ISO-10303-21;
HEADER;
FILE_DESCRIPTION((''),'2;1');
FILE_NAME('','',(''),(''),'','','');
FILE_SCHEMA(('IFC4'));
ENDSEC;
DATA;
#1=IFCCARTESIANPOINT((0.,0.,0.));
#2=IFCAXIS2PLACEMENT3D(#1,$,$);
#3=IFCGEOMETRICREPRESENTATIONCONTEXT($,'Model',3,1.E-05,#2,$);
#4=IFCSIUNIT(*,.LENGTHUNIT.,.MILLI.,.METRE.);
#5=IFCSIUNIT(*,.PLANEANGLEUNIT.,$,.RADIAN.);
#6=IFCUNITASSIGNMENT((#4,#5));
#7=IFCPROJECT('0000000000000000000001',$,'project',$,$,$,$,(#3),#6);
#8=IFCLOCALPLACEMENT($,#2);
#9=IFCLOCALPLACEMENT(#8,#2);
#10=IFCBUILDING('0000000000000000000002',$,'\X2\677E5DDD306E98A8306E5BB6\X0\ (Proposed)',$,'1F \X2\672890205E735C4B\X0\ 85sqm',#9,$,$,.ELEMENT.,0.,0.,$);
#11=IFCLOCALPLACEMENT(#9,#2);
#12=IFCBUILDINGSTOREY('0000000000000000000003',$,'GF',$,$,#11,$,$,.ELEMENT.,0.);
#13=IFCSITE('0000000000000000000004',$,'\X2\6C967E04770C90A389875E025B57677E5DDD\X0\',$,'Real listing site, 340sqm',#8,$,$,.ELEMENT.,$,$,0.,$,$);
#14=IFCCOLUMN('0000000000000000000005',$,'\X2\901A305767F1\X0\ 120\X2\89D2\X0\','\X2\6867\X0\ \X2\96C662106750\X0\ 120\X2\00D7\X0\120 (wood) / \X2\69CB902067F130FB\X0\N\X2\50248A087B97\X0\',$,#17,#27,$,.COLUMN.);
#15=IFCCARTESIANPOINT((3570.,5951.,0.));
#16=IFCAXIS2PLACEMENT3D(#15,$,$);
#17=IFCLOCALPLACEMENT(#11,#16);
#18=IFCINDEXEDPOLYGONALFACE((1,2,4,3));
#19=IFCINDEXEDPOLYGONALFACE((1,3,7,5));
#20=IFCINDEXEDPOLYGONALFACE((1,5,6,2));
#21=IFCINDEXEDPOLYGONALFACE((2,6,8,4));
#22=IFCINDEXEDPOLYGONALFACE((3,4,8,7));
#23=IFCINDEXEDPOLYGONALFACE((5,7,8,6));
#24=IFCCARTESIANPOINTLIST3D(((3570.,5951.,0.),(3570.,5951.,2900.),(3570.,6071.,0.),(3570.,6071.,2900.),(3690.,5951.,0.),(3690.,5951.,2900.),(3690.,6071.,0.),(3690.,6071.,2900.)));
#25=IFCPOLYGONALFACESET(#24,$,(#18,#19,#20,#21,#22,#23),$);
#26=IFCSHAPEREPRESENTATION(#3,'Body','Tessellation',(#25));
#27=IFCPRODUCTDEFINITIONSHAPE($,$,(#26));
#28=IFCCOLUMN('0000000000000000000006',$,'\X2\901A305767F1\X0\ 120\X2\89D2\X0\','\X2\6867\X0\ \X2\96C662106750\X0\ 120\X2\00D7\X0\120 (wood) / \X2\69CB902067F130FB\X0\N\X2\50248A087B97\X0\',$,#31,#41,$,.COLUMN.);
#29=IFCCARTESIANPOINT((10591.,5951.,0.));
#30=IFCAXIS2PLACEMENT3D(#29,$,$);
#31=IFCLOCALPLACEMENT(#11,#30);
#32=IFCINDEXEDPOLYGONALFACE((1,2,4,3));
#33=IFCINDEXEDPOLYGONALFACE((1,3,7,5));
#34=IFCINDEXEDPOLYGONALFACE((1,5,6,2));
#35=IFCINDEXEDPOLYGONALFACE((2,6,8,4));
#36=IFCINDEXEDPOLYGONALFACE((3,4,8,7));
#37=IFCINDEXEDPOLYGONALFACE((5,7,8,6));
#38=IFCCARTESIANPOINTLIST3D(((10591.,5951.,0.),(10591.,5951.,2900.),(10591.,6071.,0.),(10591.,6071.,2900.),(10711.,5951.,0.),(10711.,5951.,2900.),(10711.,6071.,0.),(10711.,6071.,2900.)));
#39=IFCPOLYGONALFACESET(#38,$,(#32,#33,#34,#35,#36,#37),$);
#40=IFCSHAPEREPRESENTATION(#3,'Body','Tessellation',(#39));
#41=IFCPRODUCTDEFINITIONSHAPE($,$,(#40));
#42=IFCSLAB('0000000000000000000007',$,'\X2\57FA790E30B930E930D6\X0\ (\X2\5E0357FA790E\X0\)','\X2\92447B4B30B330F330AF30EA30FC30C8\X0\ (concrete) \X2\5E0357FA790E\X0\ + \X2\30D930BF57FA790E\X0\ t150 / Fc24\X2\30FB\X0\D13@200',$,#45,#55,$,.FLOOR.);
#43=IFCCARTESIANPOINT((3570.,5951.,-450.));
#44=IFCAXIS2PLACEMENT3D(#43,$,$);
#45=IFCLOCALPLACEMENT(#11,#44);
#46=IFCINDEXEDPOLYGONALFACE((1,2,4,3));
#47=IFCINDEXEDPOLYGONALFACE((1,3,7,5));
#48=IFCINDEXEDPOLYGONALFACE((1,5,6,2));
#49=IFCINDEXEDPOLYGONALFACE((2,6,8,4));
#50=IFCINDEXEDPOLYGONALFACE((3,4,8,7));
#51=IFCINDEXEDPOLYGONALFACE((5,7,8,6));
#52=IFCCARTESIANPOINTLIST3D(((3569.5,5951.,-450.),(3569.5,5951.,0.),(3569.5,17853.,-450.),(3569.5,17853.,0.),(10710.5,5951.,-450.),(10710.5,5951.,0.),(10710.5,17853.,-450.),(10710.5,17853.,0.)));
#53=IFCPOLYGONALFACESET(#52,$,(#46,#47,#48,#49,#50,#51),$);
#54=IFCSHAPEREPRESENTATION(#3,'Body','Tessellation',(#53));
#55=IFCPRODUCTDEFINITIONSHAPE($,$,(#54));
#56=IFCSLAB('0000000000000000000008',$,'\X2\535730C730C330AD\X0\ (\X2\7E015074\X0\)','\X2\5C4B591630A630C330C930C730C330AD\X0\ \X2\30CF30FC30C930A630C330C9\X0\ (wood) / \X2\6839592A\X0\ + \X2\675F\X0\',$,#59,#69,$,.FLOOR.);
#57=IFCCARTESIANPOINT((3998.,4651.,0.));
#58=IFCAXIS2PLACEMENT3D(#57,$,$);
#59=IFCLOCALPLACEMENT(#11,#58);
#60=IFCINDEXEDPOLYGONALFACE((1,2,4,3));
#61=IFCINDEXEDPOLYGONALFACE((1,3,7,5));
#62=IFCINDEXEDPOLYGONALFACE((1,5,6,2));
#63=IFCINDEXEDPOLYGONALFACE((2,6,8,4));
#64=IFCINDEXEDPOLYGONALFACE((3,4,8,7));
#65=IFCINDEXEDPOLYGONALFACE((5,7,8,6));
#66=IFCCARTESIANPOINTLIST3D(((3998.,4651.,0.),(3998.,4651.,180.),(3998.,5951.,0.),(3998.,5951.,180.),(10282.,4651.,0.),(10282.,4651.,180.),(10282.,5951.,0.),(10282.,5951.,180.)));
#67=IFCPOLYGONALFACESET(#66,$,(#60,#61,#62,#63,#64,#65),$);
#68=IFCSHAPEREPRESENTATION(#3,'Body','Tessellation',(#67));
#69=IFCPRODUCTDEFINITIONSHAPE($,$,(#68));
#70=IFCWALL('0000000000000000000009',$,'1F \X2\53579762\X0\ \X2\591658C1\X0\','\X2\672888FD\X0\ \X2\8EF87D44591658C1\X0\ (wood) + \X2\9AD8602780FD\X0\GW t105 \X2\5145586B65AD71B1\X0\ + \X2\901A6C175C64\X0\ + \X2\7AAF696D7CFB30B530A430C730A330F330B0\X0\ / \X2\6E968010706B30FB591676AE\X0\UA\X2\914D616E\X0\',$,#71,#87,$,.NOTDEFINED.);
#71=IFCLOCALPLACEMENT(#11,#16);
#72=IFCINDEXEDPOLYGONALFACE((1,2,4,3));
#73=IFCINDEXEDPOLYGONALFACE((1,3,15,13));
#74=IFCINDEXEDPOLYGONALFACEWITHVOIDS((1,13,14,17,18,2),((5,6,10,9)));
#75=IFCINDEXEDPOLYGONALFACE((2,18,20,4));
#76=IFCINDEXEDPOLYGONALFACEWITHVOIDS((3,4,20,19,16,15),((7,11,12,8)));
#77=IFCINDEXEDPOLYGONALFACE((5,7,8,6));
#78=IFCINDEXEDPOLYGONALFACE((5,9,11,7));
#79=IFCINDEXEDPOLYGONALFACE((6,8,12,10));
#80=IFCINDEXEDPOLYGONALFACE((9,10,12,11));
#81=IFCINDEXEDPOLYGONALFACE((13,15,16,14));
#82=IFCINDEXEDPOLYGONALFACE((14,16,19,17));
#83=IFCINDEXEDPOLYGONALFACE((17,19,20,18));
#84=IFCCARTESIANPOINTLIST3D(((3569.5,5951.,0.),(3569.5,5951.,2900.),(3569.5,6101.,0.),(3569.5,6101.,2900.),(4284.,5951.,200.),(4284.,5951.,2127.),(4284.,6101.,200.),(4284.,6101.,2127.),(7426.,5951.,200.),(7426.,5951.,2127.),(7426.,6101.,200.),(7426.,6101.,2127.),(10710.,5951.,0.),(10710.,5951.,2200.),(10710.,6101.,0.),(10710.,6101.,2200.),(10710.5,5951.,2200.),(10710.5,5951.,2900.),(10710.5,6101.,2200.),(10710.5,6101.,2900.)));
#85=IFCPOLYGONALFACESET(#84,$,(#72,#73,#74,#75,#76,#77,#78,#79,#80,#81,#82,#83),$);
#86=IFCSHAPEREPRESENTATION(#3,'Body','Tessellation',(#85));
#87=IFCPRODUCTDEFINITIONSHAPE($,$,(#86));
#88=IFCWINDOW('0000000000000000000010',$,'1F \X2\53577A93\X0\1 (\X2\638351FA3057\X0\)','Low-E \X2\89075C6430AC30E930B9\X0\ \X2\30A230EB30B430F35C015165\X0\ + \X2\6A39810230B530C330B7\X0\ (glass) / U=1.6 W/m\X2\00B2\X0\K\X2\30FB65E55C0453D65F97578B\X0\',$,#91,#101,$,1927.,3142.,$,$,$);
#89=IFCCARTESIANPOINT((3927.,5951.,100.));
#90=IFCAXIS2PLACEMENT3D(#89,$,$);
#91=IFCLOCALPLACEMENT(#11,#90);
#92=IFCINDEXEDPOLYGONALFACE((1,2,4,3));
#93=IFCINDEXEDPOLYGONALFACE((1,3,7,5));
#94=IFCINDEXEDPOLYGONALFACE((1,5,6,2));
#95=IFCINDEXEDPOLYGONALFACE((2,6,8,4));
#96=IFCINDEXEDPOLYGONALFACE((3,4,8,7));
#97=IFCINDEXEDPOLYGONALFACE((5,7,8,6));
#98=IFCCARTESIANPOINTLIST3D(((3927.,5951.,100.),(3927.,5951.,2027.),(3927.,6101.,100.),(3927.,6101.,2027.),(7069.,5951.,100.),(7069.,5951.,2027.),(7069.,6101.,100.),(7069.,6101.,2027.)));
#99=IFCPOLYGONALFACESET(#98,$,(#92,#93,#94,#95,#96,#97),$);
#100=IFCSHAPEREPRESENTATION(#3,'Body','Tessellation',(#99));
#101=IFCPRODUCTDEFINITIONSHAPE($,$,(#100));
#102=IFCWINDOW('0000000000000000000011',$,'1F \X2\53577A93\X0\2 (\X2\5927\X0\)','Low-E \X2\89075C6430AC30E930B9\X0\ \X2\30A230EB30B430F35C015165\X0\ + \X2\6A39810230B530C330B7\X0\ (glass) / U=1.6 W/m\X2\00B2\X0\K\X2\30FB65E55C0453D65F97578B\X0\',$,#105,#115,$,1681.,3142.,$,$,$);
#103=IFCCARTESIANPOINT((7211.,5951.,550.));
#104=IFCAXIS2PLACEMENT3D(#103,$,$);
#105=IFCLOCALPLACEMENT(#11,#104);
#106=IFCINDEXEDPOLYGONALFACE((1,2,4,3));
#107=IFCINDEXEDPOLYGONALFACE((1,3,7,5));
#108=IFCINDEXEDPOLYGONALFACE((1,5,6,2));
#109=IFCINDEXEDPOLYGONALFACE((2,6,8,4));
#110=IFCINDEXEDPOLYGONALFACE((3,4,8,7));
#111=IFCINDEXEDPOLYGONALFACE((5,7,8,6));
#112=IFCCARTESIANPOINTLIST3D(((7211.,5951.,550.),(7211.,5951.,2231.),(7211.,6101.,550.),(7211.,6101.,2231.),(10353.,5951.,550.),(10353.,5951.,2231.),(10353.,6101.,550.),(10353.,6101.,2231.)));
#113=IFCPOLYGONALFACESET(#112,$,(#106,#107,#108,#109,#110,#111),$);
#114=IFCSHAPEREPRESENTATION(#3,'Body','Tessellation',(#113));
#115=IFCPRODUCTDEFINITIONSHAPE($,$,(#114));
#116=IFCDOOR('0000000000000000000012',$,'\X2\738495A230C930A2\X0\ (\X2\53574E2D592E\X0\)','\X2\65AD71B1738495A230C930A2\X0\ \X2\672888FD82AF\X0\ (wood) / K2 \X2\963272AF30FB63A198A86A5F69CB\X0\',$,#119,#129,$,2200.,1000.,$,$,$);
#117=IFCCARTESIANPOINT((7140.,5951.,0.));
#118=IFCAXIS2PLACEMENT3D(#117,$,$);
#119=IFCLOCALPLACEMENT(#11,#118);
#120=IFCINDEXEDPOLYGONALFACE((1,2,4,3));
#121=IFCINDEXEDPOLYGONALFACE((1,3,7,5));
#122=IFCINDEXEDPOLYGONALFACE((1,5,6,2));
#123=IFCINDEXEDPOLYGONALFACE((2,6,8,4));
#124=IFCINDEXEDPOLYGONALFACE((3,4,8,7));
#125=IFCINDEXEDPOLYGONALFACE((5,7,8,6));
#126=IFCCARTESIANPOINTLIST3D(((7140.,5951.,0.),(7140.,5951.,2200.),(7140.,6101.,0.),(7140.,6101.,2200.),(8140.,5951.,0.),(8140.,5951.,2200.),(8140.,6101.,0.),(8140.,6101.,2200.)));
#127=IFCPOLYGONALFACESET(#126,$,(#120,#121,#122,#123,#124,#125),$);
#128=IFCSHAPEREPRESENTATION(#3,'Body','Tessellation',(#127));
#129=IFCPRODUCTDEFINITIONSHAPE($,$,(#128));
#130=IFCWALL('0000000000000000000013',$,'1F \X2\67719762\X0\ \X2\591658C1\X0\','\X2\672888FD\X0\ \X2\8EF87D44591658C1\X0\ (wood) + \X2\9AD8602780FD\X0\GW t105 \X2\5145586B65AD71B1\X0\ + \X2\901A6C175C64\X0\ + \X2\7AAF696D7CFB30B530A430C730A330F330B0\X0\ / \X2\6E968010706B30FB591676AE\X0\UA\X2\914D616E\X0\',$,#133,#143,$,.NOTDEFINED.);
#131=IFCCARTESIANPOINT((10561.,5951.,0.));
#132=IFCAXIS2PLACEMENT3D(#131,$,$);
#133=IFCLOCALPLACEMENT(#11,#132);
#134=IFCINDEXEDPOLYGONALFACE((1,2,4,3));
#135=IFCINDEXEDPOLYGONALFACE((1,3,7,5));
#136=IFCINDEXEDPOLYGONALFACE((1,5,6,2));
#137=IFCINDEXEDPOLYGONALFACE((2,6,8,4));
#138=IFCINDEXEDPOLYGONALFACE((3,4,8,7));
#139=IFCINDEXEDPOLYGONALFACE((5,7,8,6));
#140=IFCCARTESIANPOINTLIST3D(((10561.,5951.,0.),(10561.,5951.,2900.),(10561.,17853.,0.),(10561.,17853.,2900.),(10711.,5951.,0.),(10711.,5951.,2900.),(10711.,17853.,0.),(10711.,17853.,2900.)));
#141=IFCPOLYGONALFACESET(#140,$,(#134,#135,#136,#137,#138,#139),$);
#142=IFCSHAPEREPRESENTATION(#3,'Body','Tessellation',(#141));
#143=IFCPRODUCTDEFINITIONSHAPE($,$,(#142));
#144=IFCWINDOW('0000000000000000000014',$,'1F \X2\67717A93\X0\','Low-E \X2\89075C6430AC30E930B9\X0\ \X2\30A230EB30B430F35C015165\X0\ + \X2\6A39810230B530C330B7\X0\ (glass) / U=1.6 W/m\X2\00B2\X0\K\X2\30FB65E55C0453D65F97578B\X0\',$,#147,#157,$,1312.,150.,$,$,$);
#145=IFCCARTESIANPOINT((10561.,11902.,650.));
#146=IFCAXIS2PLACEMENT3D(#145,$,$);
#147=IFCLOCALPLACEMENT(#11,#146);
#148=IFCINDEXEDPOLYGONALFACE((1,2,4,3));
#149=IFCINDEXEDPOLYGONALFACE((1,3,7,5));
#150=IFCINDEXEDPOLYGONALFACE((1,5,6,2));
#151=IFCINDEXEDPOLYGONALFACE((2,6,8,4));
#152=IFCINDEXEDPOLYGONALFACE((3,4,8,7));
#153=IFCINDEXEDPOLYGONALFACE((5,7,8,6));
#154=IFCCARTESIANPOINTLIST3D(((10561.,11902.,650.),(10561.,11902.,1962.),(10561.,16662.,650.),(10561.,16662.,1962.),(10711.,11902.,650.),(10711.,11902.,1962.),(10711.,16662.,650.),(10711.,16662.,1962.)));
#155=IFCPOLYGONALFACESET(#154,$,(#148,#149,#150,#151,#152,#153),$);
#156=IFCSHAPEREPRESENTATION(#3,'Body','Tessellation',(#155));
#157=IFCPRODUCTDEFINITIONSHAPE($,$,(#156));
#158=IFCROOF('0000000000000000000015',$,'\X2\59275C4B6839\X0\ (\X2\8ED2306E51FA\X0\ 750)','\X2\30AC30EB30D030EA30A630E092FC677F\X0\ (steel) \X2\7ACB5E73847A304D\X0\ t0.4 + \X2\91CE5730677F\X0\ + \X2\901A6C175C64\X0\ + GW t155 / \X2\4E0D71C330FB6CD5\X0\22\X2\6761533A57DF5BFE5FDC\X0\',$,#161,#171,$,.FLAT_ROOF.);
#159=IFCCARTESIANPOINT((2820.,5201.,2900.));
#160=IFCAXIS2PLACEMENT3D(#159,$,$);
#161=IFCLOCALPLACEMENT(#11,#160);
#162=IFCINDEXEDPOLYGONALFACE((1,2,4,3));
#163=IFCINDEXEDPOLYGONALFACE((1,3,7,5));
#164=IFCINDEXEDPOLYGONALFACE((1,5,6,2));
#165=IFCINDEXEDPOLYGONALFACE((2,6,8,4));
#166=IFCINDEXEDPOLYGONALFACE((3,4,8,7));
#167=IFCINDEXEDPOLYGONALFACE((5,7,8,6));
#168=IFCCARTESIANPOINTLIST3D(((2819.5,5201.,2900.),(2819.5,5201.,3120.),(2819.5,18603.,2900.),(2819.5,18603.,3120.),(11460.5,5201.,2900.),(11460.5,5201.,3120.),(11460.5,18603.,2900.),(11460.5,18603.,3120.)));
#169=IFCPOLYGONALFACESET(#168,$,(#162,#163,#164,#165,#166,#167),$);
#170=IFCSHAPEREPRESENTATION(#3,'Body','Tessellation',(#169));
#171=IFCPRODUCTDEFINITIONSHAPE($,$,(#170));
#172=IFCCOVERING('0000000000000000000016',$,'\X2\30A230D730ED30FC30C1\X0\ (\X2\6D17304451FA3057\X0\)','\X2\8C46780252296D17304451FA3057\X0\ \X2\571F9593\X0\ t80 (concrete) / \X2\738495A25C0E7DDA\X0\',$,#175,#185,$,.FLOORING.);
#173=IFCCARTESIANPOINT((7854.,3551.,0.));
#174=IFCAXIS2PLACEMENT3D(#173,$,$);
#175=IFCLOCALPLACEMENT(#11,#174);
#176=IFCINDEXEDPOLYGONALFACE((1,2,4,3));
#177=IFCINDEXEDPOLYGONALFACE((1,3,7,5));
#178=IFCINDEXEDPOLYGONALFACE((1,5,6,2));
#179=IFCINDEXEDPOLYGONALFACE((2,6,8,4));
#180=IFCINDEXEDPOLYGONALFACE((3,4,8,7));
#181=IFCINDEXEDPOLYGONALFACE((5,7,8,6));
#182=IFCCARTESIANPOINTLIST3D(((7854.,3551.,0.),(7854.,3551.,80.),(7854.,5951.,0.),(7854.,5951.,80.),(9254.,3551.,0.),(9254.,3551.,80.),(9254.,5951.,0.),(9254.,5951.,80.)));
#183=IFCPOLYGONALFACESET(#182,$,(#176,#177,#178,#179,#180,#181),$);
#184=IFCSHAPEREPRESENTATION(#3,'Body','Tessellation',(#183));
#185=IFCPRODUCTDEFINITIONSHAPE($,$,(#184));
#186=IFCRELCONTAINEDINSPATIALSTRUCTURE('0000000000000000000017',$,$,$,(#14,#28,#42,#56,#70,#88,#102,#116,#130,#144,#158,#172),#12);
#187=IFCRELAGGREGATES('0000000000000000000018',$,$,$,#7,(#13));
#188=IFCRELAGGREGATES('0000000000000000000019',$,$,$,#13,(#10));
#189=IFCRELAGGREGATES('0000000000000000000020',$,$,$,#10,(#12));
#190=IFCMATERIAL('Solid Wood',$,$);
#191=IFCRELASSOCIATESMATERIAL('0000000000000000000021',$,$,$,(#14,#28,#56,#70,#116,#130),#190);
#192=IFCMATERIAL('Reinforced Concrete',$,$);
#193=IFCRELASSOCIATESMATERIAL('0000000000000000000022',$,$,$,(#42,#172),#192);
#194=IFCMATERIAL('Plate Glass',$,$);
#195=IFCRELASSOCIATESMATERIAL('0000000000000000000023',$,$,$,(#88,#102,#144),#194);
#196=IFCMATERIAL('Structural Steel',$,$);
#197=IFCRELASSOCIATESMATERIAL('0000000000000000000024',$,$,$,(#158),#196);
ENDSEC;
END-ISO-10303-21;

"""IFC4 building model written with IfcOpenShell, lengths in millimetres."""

from ifc_helpers import new_model, si_unit, frame, frame_2d, origin, place, context, project, spatial, rectangle, extrude, material, element, fill, save


model = new_model("IFC4")

# Units and contexts
model_context = context("Model", 3, precision=1e-05, world=origin())
ifc_project = project(units=[si_unit("LENGTHUNIT", "METRE", prefix="MILLI"), si_unit("PLANEANGLEUNIT", "RADIAN")], contexts=[model_context])

# Site, building, storey
site_placement = place(None, origin())
site = spatial("IfcSite", under=ifc_project, at=site_placement, Name="沖縄県那覇市字松川", ObjectType="Real listing site, 340sqm", CompositionType="ELEMENT", RefElevation=0.0)
building_placement = place(site_placement, origin())
building = spatial("IfcBuilding", under=site, at=building_placement, Name="松川の風の家 (Proposed)", ObjectType="1F 木造平屋 85sqm", CompositionType="ELEMENT", ElevationOfRefHeight=0.0, ElevationOfTerrain=0.0)
storey_placement = place(building_placement, origin())
storey = spatial("IfcBuildingStorey", under=building, at=storey_placement, Name="GF", CompositionType="ELEMENT", Elevation=0.0)

# Columns
ifc_material_1 = material(Name="Solid Wood")
column_1_placement = place(storey_placement, frame((3570.0, 5951.0, 0.0)))
element("IfcColumn", 1, at=column_1_placement, inside=storey, material=ifc_material_1, Name="通し柱 120角", Description="桧 集成材 120×120 (wood) / 構造柱・N値計算", PredefinedType="COLUMN", context=model_context, shape_type="SweptSolid", body=[
    extrude(rectangle(XDim=120.0, YDim=120.0, at=frame_2d((60.0, 60.0))), frame((3570.0, 5951.0, 0.0)), (0.0, 0.0, 1.0), 2900.0),
])
column_2_placement = place(storey_placement, frame((10591.0, 5951.0, 0.0)))
element("IfcColumn", 2, at=column_2_placement, inside=storey, material=ifc_material_1, Name="通し柱 120角", Description="桧 集成材 120×120 (wood) / 構造柱・N値計算", PredefinedType="COLUMN", context=model_context, shape_type="SweptSolid", body=[
    extrude(rectangle(XDim=120.0, YDim=120.0, at=frame_2d((60.0, 60.0))), frame((10591.0, 5951.0, 0.0)), (0.0, 0.0, 1.0), 2900.0),
])

# Slabs
ifc_material_2 = material(Name="Reinforced Concrete")
slab_1_placement = place(storey_placement, frame((3570.0, 5951.0, -450.0)))
element("IfcSlab", 3, at=slab_1_placement, inside=storey, material=ifc_material_2, Name="基礎スラブ (布基礎)", Description="鉄筋コンクリート (concrete) 布基礎 + ベタ基礎 t150 / Fc24・D13@200", PredefinedType="FLOOR", context=model_context, shape_type="SweptSolid", body=[
    extrude(rectangle(XDim=7141.0, YDim=11902.0, at=frame_2d((3570.0, 5951.0))), frame((3570.0, 5951.0, -450.0)), (0.0, 0.0, 1.0), 450.0),
])
slab_2_placement = place(storey_placement, frame((3998.0, 4651.0, 0.0)))
element("IfcSlab", 4, at=slab_2_placement, inside=storey, material=ifc_material_1, Name="南デッキ (縁側)", Description="屋外ウッドデッキ ハードウッド (wood) / 根太 + 束", PredefinedType="FLOOR", context=model_context, shape_type="SweptSolid", body=[
    extrude(rectangle(XDim=6284.0, YDim=1300.0, at=frame_2d((3142.0, 650.0))), frame((3998.0, 4651.0, 0.0)), (0.0, 0.0, 1.0), 180.0),
])

# Wall, openings, windows, door
wall_1_placement = place(storey_placement, frame((3570.0, 5951.0, 0.0)))
wall_1 = element("IfcWall", 5, at=wall_1_placement, inside=storey, material=ifc_material_1, Name="1F 南面 外壁", Description="木製 軸組外壁 (wood) + 高性能GW t105 充填断熱 + 通気層 + 窯業系サイディング / 準耐火・外皮UA配慮", PredefinedType="NOTDEFINED", context=model_context, shape_type="SweptSolid", body=[
    extrude(rectangle(XDim=7141.0, YDim=150.0, at=frame_2d((3570.0, 75.0))), frame((3570.0, 5951.0, 0.0)), (0.0, 0.0, 1.0), 2900.0),
])
opening_1_placement = place(storey_placement, frame((3927.0, 5951.0, 100.0)))
opening_1 = element("IfcOpeningElement", 6, at=opening_1_placement, cuts=wall_1, PredefinedType="NOTDEFINED", context=model_context, shape_type="SweptSolid", body=[
    extrude(rectangle(XDim=3142.0, YDim=150.0, at=frame_2d((1571.0, 75.0))), frame((3927.0, 5951.0, 100.0)), (0.0, 0.0, 1.0), 1927.0),
])
opening_2_placement = place(storey_placement, frame((7211.0, 5951.0, 550.0)))
opening_2 = element("IfcOpeningElement", 7, at=opening_2_placement, cuts=wall_1, PredefinedType="NOTDEFINED", context=model_context, shape_type="SweptSolid", body=[
    extrude(rectangle(XDim=3142.0, YDim=150.0, at=frame_2d((1571.0, 75.0))), frame((7211.0, 5951.0, 550.0)), (0.0, 0.0, 1.0), 1681.0),
])
opening_3_placement = place(storey_placement, frame((7140.0, 5951.0, 0.0)))
opening_3 = element("IfcOpeningElement", 8, at=opening_3_placement, cuts=wall_1, PredefinedType="NOTDEFINED", context=model_context, shape_type="SweptSolid", body=[
    extrude(rectangle(XDim=1000.0, YDim=150.0, at=frame_2d((500.0, 75.0))), frame((7140.0, 5951.0, 0.0)), (0.0, 0.0, 1.0), 2200.0),
])
ifc_material_3 = material(Name="Plate Glass")
window_1_placement = place(storey_placement, frame((3927.0, 5951.0, 100.0)))
window_1 = element("IfcWindow", 9, at=window_1_placement, inside=storey, material=ifc_material_3, Name="1F 南窓1 (掃出し)", Description="Low-E 複層ガラス アルゴン封入 + 樹脂サッシ (glass) / U=1.6 W/m²K・日射取得型", OverallHeight=1927.0, OverallWidth=3142.0, context=model_context, shape_type="SweptSolid", body=[
    extrude(rectangle(XDim=3142.0, YDim=150.0, at=frame_2d((1571.0, 75.0))), frame((3927.0, 5951.0, 100.0)), (0.0, 0.0, 1.0), 1927.0),
])
fill(opening_1, window_1)
window_2_placement = place(storey_placement, frame((7211.0, 5951.0, 550.0)))
window_2 = element("IfcWindow", 10, at=window_2_placement, inside=storey, material=ifc_material_3, Name="1F 南窓2 (大)", Description="Low-E 複層ガラス アルゴン封入 + 樹脂サッシ (glass) / U=1.6 W/m²K・日射取得型", OverallHeight=1681.0, OverallWidth=3142.0, context=model_context, shape_type="SweptSolid", body=[
    extrude(rectangle(XDim=3142.0, YDim=150.0, at=frame_2d((1571.0, 75.0))), frame((7211.0, 5951.0, 550.0)), (0.0, 0.0, 1.0), 1681.0),
])
fill(opening_2, window_2)
door_placement = place(storey_placement, frame((7140.0, 5951.0, 0.0)))
door = element("IfcDoor", 11, at=door_placement, inside=storey, material=ifc_material_1, Name="玄関ドア (南中央)", Description="断熱玄関ドア 木製芯 (wood) / K2 防犯・採風機構", OverallHeight=2200.0, OverallWidth=1000.0, context=model_context, shape_type="SweptSolid", body=[
    extrude(rectangle(XDim=1000.0, YDim=150.0, at=frame_2d((500.0, 75.0))), frame((7140.0, 5951.0, 0.0)), (0.0, 0.0, 1.0), 2200.0),
])
fill(opening_3, door)

# Wall, opening, window
wall_2_placement = place(storey_placement, frame((10561.0, 5951.0, 0.0)))
wall_2 = element("IfcWall", 12, at=wall_2_placement, inside=storey, material=ifc_material_1, Name="1F 東面 外壁", Description="木製 軸組外壁 (wood) + 高性能GW t105 充填断熱 + 通気層 + 窯業系サイディング / 準耐火・外皮UA配慮", PredefinedType="NOTDEFINED", context=model_context, shape_type="SweptSolid", body=[
    extrude(rectangle(XDim=150.0, YDim=11902.0, at=frame_2d((75.0, 5951.0))), frame((10561.0, 5951.0, 0.0)), (0.0, 0.0, 1.0), 2900.0),
])
opening_4_placement = place(storey_placement, frame((10561.0, 11902.0, 650.0)))
opening_4 = element("IfcOpeningElement", 13, at=opening_4_placement, cuts=wall_2, PredefinedType="NOTDEFINED", context=model_context, shape_type="SweptSolid", body=[
    extrude(rectangle(XDim=150.0, YDim=4760.0, at=frame_2d((75.0, 2380.0))), frame((10561.0, 11902.0, 650.0)), (0.0, 0.0, 1.0), 1312.0),
])
window_3_placement = place(storey_placement, frame((10561.0, 11902.0, 650.0)))
window_3 = element("IfcWindow", 14, at=window_3_placement, inside=storey, material=ifc_material_3, Name="1F 東窓", Description="Low-E 複層ガラス アルゴン封入 + 樹脂サッシ (glass) / U=1.6 W/m²K・日射取得型", OverallHeight=1312.0, OverallWidth=150.0, context=model_context, shape_type="SweptSolid", body=[
    extrude(rectangle(XDim=150.0, YDim=4760.0, at=frame_2d((75.0, 2380.0))), frame((10561.0, 11902.0, 650.0)), (0.0, 0.0, 1.0), 1312.0),
])
fill(opening_4, window_3)

# Roof
ifc_material_4 = material(Name="Structural Steel")
roof_placement = place(storey_placement, frame((2820.0, 5201.0, 2900.0)))
element("IfcRoof", 15, at=roof_placement, inside=storey, material=ifc_material_4, Name="大屋根 (軒の出 750)", Description="ガルバリウム鋼板 (steel) 立平葺き t0.4 + 野地板 + 通気層 + GW t155 / 不燃・法22条区域対応", PredefinedType="FLAT_ROOF", context=model_context, shape_type="SweptSolid", body=[
    extrude(rectangle(XDim=8641.0, YDim=13402.0, at=frame_2d((4320.0, 6701.0))), frame((2820.0, 5201.0, 2900.0)), (0.0, 0.0, 1.0), 220.0),
])

# Covering
covering_1_placement = place(storey_placement, frame((7854.0, 3551.0, 0.0)))
element("IfcCovering", 16, at=covering_1_placement, inside=storey, material=ifc_material_2, Name="アプローチ (洗い出し)", Description="豆砂利洗い出し 土間 t80 (concrete) / 玄関導線", PredefinedType="FLOORING", context=model_context, shape_type="SweptSolid", body=[
    extrude(rectangle(XDim=1400.0, YDim=2400.0, at=frame_2d((700.0, 1200.0))), frame((7854.0, 3551.0, 0.0)), (0.0, 0.0, 1.0), 80.0),
])

save(model, "model.ifc")
